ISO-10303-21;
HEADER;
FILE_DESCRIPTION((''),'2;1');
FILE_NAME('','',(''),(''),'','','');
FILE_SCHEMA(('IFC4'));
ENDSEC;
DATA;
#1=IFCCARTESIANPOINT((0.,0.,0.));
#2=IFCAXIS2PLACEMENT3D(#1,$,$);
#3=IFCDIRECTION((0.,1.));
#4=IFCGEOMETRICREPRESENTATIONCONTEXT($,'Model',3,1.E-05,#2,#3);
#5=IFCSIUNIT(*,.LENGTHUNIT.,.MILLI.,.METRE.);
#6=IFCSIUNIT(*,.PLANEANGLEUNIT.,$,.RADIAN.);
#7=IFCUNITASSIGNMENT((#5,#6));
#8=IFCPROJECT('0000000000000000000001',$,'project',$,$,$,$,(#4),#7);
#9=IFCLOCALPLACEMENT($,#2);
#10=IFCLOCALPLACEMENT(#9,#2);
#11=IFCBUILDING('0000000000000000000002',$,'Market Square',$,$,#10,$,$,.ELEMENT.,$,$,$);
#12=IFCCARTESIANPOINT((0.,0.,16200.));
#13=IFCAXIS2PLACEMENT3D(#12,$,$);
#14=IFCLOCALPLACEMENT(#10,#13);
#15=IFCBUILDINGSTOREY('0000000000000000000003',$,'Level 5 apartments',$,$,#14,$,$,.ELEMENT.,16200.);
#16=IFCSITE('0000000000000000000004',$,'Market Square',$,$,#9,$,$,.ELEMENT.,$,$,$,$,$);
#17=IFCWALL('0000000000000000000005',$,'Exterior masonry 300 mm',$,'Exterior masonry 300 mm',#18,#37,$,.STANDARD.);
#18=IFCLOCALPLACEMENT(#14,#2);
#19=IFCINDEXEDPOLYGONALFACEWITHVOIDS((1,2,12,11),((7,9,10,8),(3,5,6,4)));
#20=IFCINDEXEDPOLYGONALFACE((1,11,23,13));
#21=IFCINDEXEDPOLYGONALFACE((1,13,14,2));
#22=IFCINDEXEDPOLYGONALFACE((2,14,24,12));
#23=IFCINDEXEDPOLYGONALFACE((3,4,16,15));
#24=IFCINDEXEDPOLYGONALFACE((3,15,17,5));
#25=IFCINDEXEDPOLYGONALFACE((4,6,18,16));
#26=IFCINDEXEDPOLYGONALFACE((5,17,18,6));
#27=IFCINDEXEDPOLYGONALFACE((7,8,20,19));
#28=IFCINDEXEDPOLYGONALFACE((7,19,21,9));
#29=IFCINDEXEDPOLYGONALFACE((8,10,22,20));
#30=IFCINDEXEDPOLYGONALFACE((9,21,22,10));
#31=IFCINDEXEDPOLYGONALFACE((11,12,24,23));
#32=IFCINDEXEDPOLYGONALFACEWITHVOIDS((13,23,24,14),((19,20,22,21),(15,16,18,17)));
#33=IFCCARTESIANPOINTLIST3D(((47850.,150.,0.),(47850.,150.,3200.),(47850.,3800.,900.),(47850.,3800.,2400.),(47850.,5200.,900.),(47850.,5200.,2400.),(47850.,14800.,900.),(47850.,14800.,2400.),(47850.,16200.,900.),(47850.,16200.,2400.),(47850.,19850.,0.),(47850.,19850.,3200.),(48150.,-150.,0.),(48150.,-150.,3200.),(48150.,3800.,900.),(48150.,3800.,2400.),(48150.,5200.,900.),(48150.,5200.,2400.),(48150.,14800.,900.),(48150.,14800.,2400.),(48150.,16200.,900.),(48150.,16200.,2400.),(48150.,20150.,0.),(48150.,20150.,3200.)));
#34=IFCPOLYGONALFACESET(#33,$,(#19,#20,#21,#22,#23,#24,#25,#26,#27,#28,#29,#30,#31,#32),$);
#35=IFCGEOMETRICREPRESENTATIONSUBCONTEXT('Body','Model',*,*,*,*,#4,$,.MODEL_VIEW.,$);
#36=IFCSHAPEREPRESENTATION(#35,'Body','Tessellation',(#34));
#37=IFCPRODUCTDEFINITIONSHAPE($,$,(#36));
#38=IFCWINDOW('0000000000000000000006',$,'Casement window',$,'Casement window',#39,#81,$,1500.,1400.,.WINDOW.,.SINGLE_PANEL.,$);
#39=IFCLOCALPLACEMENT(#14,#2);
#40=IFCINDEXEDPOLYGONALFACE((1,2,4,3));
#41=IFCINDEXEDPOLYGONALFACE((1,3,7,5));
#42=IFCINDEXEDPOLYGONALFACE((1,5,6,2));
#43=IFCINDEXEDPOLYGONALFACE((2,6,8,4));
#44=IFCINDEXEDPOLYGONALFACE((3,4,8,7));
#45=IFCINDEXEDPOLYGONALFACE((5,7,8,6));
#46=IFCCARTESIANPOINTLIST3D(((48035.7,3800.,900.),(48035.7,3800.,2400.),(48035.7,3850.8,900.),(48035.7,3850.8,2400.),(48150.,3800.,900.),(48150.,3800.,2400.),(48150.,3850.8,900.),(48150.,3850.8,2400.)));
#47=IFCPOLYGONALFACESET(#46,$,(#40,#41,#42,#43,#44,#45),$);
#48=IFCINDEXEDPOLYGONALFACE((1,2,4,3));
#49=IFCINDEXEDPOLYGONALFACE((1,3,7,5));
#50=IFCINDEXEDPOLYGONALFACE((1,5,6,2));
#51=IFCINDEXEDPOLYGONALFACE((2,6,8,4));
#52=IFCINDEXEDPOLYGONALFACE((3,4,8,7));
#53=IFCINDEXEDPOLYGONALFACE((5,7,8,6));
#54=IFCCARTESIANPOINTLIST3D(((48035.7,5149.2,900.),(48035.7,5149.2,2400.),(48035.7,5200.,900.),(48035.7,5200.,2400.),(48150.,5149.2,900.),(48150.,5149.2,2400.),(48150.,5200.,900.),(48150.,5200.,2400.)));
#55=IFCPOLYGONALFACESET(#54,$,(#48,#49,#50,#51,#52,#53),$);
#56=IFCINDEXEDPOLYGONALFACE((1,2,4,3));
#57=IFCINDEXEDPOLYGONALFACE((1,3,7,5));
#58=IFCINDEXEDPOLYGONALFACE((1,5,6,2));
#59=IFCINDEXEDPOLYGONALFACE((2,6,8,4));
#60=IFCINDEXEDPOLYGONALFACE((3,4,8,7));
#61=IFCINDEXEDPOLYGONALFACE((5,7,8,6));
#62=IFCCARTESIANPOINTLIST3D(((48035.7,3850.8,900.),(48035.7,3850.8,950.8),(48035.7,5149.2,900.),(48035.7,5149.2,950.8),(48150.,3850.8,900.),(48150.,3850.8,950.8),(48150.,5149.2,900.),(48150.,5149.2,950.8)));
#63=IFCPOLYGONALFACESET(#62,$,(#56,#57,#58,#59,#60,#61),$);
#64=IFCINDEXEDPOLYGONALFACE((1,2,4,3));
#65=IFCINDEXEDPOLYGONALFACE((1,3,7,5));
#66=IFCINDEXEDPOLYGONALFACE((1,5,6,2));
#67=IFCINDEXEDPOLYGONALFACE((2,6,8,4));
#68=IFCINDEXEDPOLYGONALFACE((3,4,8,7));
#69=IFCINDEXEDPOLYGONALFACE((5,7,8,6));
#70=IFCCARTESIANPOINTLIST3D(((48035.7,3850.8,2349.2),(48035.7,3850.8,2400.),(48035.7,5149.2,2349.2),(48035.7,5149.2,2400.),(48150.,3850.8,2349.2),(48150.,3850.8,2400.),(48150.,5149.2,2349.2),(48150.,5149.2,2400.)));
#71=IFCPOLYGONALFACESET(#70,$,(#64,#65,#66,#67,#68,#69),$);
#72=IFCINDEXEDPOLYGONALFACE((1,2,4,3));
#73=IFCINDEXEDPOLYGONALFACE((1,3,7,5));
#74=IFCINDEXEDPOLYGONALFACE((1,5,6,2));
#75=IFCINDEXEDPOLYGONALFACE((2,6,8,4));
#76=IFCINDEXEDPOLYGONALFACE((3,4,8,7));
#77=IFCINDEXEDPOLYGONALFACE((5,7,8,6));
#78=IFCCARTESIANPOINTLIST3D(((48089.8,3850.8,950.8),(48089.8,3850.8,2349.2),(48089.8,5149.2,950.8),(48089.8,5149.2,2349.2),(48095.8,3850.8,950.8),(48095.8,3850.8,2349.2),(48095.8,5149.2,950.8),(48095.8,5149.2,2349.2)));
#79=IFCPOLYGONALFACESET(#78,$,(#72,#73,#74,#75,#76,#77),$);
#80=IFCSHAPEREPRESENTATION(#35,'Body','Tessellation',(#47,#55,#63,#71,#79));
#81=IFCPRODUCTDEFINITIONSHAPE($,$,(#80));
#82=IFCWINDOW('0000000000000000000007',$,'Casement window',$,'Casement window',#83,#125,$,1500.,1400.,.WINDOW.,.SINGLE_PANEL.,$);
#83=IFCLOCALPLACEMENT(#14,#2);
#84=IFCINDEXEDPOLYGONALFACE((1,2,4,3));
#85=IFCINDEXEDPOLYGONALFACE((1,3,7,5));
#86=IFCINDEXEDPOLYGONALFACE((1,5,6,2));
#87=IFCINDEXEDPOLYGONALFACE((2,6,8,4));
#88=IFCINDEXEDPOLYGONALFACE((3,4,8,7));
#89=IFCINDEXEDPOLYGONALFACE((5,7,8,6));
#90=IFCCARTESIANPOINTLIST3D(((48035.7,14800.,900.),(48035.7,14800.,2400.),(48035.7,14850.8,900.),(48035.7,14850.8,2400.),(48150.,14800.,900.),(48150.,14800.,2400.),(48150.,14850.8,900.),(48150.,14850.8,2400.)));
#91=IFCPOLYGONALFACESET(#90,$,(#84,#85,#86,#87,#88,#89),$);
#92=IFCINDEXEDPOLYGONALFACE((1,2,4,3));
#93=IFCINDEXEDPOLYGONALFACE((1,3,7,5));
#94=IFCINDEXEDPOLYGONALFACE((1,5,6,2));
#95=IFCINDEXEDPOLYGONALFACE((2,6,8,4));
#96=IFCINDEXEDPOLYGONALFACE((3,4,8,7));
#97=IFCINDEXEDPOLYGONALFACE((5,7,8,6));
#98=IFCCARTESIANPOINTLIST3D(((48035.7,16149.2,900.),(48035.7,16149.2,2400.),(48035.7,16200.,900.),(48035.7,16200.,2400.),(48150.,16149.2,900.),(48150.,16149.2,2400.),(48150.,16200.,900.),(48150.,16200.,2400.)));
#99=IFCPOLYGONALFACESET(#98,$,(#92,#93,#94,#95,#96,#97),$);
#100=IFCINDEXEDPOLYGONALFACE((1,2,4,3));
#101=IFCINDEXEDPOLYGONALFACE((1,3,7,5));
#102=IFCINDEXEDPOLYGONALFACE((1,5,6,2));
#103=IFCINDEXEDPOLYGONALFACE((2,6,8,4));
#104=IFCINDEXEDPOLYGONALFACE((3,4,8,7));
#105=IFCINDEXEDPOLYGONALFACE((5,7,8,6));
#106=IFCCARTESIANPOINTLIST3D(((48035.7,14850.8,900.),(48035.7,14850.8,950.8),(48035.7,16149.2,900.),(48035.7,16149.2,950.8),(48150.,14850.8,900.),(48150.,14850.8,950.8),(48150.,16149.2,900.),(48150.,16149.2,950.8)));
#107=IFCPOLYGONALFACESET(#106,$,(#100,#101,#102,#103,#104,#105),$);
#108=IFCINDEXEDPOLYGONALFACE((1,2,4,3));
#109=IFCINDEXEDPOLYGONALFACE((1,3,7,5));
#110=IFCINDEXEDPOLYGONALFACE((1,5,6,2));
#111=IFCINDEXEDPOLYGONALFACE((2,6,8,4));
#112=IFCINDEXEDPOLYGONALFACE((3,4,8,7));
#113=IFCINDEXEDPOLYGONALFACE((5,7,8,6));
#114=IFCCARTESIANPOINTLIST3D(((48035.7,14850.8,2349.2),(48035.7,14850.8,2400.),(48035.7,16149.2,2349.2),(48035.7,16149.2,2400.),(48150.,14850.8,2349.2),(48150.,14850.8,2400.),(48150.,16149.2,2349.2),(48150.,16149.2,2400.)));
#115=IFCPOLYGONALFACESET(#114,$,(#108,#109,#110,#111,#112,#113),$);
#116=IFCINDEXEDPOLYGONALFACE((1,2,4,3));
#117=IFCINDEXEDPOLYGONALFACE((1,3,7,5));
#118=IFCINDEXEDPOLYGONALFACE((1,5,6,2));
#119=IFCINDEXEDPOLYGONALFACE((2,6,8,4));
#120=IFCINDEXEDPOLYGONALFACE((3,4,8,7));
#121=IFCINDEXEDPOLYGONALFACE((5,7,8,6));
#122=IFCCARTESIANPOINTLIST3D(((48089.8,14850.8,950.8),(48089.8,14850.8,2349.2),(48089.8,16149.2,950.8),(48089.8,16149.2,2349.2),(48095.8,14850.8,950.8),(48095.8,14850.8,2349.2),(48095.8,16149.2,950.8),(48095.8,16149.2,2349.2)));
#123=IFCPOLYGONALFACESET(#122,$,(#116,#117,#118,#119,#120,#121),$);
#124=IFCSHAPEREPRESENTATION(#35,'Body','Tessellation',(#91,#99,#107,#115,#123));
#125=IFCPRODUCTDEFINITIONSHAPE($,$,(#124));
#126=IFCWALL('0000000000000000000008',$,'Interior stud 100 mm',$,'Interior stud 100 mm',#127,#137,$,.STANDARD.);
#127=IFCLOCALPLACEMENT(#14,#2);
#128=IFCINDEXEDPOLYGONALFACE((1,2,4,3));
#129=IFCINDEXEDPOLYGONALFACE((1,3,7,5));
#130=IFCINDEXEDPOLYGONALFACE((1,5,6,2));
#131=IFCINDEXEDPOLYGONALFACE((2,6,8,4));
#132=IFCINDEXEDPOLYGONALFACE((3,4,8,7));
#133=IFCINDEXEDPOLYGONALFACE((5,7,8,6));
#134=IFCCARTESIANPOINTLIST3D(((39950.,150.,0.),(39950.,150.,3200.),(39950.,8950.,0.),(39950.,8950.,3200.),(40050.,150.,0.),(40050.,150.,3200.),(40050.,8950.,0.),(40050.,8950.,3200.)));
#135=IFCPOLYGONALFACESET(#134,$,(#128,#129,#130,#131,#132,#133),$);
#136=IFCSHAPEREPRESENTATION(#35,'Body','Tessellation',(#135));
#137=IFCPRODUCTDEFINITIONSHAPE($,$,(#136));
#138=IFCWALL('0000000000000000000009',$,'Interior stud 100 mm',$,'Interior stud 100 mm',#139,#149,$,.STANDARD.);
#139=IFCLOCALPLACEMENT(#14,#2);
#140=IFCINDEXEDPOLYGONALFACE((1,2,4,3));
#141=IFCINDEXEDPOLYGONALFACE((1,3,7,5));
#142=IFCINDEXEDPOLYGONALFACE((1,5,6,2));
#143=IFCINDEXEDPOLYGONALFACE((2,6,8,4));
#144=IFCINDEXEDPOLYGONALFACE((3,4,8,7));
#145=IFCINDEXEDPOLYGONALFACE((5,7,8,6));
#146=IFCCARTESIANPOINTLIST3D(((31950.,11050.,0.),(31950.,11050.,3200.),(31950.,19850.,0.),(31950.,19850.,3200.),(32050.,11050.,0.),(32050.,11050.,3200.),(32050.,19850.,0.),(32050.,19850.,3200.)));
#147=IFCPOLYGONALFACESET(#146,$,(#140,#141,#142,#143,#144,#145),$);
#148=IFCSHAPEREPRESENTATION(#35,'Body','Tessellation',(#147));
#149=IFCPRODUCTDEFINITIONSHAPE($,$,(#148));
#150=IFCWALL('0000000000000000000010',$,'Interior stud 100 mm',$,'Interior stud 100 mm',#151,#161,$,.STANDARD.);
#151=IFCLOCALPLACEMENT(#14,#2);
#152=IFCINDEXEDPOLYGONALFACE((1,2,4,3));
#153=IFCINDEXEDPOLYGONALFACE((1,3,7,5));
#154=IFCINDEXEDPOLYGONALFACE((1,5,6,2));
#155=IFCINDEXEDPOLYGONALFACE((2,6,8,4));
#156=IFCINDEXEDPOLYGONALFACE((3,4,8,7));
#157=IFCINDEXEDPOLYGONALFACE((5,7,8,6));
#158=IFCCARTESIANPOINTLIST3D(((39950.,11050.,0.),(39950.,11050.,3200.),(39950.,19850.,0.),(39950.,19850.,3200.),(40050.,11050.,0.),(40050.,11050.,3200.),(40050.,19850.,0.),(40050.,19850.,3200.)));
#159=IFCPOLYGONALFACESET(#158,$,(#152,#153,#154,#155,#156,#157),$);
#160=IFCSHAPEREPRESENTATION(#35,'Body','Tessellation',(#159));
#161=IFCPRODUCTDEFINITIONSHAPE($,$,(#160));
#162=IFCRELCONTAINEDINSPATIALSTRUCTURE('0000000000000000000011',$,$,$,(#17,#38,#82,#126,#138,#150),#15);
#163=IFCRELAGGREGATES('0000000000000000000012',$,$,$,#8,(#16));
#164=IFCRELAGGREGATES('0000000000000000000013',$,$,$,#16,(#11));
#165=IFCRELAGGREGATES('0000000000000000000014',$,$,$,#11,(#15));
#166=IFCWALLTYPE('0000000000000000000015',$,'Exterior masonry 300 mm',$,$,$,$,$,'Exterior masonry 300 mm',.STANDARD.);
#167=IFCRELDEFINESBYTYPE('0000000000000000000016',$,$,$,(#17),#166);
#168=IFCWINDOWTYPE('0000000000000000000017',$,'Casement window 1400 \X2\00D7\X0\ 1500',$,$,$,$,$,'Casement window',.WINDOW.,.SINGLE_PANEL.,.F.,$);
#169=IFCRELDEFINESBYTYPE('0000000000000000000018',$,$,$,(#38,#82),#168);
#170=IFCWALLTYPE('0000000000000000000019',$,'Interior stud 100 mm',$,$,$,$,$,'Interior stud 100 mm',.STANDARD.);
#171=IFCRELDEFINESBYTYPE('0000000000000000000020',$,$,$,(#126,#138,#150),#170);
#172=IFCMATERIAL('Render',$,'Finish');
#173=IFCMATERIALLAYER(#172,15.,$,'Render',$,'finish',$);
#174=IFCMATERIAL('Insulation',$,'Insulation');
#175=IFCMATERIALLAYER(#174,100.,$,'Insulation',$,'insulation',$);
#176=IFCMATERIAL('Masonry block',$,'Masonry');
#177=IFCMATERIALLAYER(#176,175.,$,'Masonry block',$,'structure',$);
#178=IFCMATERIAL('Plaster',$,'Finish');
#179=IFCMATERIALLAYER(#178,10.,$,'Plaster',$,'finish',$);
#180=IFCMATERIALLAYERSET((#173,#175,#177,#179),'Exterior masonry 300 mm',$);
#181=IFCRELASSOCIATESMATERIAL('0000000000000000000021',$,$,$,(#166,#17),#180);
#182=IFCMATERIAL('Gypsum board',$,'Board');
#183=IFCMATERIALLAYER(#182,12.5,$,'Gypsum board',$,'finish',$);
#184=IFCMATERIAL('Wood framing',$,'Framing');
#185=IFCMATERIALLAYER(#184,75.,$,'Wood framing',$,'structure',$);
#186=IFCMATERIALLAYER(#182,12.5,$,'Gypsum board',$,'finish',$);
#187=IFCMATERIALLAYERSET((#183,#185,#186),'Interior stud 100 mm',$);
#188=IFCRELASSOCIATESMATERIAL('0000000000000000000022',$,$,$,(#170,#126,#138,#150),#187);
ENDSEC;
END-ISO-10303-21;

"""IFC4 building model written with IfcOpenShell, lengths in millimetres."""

from ifc_helpers import new_model, si_unit, direction, frame, origin, origin_with_axes, place, context, subcontext, project, spatial, polyline, outline, extrude, material, layer, layer_set, layer_usage, type_object, element, fill, save


model = new_model("IFC4")

# Units and contexts
model_context = context("Model", 3, precision=1e-05, world=origin(), true_north=direction((0.0, 1.0)))
body_context = subcontext(model_context, "Body", "Model", "MODEL_VIEW")
ifc_project = project(units=[si_unit("LENGTHUNIT", "METRE", prefix="MILLI"), si_unit("PLANEANGLEUNIT", "RADIAN")], contexts=[model_context])

# Site, building, storey
site_placement = place(None, origin())
site = spatial("IfcSite", under=ifc_project, at=site_placement, Name="Market Square", CompositionType="ELEMENT")
building_placement = place(site_placement, origin())
building = spatial("IfcBuilding", under=site, at=building_placement, Name="Market Square", CompositionType="ELEMENT")
storey_placement = place(building_placement, frame((0.0, 0.0, 16200.0)))
storey = spatial("IfcBuildingStorey", under=building, at=storey_placement, Name="Level 5 apartments", CompositionType="ELEMENT", Elevation=16200.0)

# Wall, openings, windows
ifc_material_1 = material(Name="Render", Category="Finish")
ifc_layer_1 = layer(ifc_material_1, 15.0, Name="Render", Category="finish")
ifc_material_2 = material(Name="Insulation", Category="Insulation")
ifc_layer_2 = layer(ifc_material_2, 100.0, Name="Insulation", Category="insulation")
ifc_material_3 = material(Name="Masonry block", Category="Masonry")
ifc_layer_3 = layer(ifc_material_3, 175.0, Name="Masonry block", Category="structure")
ifc_material_4 = material(Name="Plaster", Category="Finish")
ifc_layer_4 = layer(ifc_material_4, 10.0, Name="Plaster", Category="finish")
ifc_layer_set_1 = layer_set([ifc_layer_1, ifc_layer_2, ifc_layer_3, ifc_layer_4], Name="Exterior masonry 300 mm")
ifc_layer_usage_1 = layer_usage(ifc_layer_set_1, "AXIS2", "POSITIVE", -150.0)
wall_type_1 = type_object("IfcWallType", Name="Exterior masonry 300 mm", ElementType="Exterior masonry 300 mm", PredefinedType="STANDARD", material=ifc_layer_set_1)
wall_1_placement = place(storey_placement, frame((48000.0, 0.0, 0.0), z_axis=(0.0, 0.0, 1.0), x_axis=(0.0, 1.0, 0.0)))
wall_1 = element("IfcWall", 1, at=wall_1_placement, inside=storey, type_object=wall_type_1, material=ifc_layer_usage_1, Name="Exterior masonry 300 mm", ObjectType="Exterior masonry 300 mm", PredefinedType="STANDARD", context=body_context, shape_type="SweptSolid", body=[
    extrude(outline(polyline([(-150.0, -150.0), (20150.0, -150.0), (19850.0, 150.0), (150.0, 150.0), (-150.0, -150.0)])), origin(), (0.0, 0.0, 1.0), 3200.0),
])
opening_1_placement = place(wall_1_placement, frame((3800.0, 0.0, 900.0), z_axis=(0.0, 0.0, 1.0), x_axis=(1.0, 0.0, 0.0)))
opening_1 = element("IfcOpeningElement", 2, at=opening_1_placement, cuts=wall_1, PredefinedType="OPENING", context=body_context, shape_type="SweptSolid", body=[
    extrude(outline(polyline([(0.0, -160.0), (1400.0, -160.0), (1400.0, 160.0), (0.0, 160.0), (0.0, -160.0)])), origin(), (0.0, 0.0, 1.0), 1500.0),
])
opening_2_placement = place(wall_1_placement, frame((14800.0, 0.0, 900.0), z_axis=(0.0, 0.0, 1.0), x_axis=(1.0, 0.0, 0.0)))
opening_2 = element("IfcOpeningElement", 3, at=opening_2_placement, cuts=wall_1, PredefinedType="OPENING", context=body_context, shape_type="SweptSolid", body=[
    extrude(outline(polyline([(0.0, -160.0), (1400.0, -160.0), (1400.0, 160.0), (0.0, 160.0), (0.0, -160.0)])), origin(), (0.0, 0.0, 1.0), 1500.0),
])
window_type = type_object("IfcWindowType", Name="Casement window 1400 × 1500", ElementType="Casement window", ParameterTakesPrecedence=False, PartitioningType="SINGLE_PANEL", PredefinedType="WINDOW")
window_1_placement = place(opening_1_placement, origin_with_axes())
window_1 = element("IfcWindow", 4, at=window_1_placement, inside=storey, type_object=window_type, Name="Casement window", ObjectType="Casement window", OverallHeight=1500.0, OverallWidth=1400.0, PartitioningType="SINGLE_PANEL", PredefinedType="WINDOW", context=body_context, shape_type="SweptSolid", body=[
    extrude(outline(polyline([(0.0, -150.0), (50.8, -150.0), (50.8, -35.7), (0.0, -35.7), (0.0, -150.0)])), origin(), (0.0, 0.0, 1.0), 1500.0),
    extrude(outline(polyline([(1349.2, -150.0), (1400.0, -150.0), (1400.0, -35.7), (1349.2, -35.7), (1349.2, -150.0)])), origin(), (0.0, 0.0, 1.0), 1500.0),
    extrude(outline(polyline([(50.8, -150.0), (1349.2, -150.0), (1349.2, -35.7), (50.8, -35.7), (50.8, -150.0)])), origin(), (0.0, 0.0, 1.0), 50.8),
    extrude(outline(polyline([(50.8, -150.0), (1349.2, -150.0), (1349.2, -35.7), (50.8, -35.7), (50.8, -150.0)])), frame((0.0, 0.0, 1449.2)), (0.0, 0.0, 1.0), 50.8),
    extrude(outline(polyline([(50.8, -95.8), (1349.2, -95.8), (1349.2, -89.8), (50.8, -89.8), (50.8, -95.8)])), frame((0.0, 0.0, 50.8)), (0.0, 0.0, 1.0), 1398.4),
])
fill(opening_1, window_1)
window_2_placement = place(opening_2_placement, origin_with_axes())
window_2 = element("IfcWindow", 5, at=window_2_placement, inside=storey, type_object=window_type, Name="Casement window", ObjectType="Casement window", OverallHeight=1500.0, OverallWidth=1400.0, PartitioningType="SINGLE_PANEL", PredefinedType="WINDOW", context=body_context, shape_type="SweptSolid", body=[
    extrude(outline(polyline([(0.0, -150.0), (50.8, -150.0), (50.8, -35.7), (0.0, -35.7), (0.0, -150.0)])), origin(), (0.0, 0.0, 1.0), 1500.0),
    extrude(outline(polyline([(1349.2, -150.0), (1400.0, -150.0), (1400.0, -35.7), (1349.2, -35.7), (1349.2, -150.0)])), origin(), (0.0, 0.0, 1.0), 1500.0),
    extrude(outline(polyline([(50.8, -150.0), (1349.2, -150.0), (1349.2, -35.7), (50.8, -35.7), (50.8, -150.0)])), origin(), (0.0, 0.0, 1.0), 50.8),
    extrude(outline(polyline([(50.8, -150.0), (1349.2, -150.0), (1349.2, -35.7), (50.8, -35.7), (50.8, -150.0)])), frame((0.0, 0.0, 1449.2)), (0.0, 0.0, 1.0), 50.8),
    extrude(outline(polyline([(50.8, -95.8), (1349.2, -95.8), (1349.2, -89.8), (50.8, -89.8), (50.8, -95.8)])), frame((0.0, 0.0, 50.8)), (0.0, 0.0, 1.0), 1398.4),
])
fill(opening_2, window_2)

# Walls
ifc_material_5 = material(Name="Gypsum board", Category="Board")
ifc_layer_5 = layer(ifc_material_5, 12.5, Name="Gypsum board", Category="finish")
ifc_material_6 = material(Name="Wood framing", Category="Framing")
ifc_layer_6 = layer(ifc_material_6, 75.0, Name="Wood framing", Category="structure")
ifc_layer_7 = layer(ifc_material_5, 12.5, Name="Gypsum board", Category="finish")
ifc_layer_set_2 = layer_set([ifc_layer_5, ifc_layer_6, ifc_layer_7], Name="Interior stud 100 mm")
ifc_layer_usage_2 = layer_usage(ifc_layer_set_2, "AXIS2", "NEGATIVE", 50.0)
wall_type_2 = type_object("IfcWallType", Name="Interior stud 100 mm", ElementType="Interior stud 100 mm", PredefinedType="STANDARD", material=ifc_layer_set_2)
wall_2_placement = place(storey_placement, frame((40000.0, 0.0, 0.0), z_axis=(0.0, 0.0, 1.0), x_axis=(0.0, 1.0, 0.0)))
element("IfcWall", 6, at=wall_2_placement, inside=storey, type_object=wall_type_2, material=ifc_layer_usage_2, Name="Interior stud 100 mm", ObjectType="Interior stud 100 mm", PredefinedType="STANDARD", context=body_context, shape_type="SweptSolid", body=[
    extrude(outline(polyline([(150.0, -50.0), (8950.0, -50.0), (8950.0, 50.0), (150.0, 50.0), (150.0, -50.0)])), origin(), (0.0, 0.0, 1.0), 3200.0),
])
ifc_layer_usage_3 = layer_usage(ifc_layer_set_2, "AXIS2", "NEGATIVE", 50.0)
wall_3_placement = place(storey_placement, frame((32000.0, 11000.0, 0.0), z_axis=(0.0, 0.0, 1.0), x_axis=(0.0, 1.0, 0.0)))
element("IfcWall", 7, at=wall_3_placement, inside=storey, type_object=wall_type_2, material=ifc_layer_usage_3, Name="Interior stud 100 mm", ObjectType="Interior stud 100 mm", PredefinedType="STANDARD", context=body_context, shape_type="SweptSolid", body=[
    extrude(outline(polyline([(50.0, -50.0), (8850.0, -50.0), (8850.0, 50.0), (50.0, 50.0), (50.0, -50.0)])), origin(), (0.0, 0.0, 1.0), 3200.0),
])
ifc_layer_usage_4 = layer_usage(ifc_layer_set_2, "AXIS2", "NEGATIVE", 50.0)
wall_4_placement = place(storey_placement, frame((40000.0, 11000.0, 0.0), z_axis=(0.0, 0.0, 1.0), x_axis=(0.0, 1.0, 0.0)))
element("IfcWall", 8, at=wall_4_placement, inside=storey, type_object=wall_type_2, material=ifc_layer_usage_4, Name="Interior stud 100 mm", ObjectType="Interior stud 100 mm", PredefinedType="STANDARD", context=body_context, shape_type="SweptSolid", body=[
    extrude(outline(polyline([(50.0, -50.0), (8850.0, -50.0), (8850.0, 50.0), (50.0, 50.0), (50.0, -50.0)])), origin(), (0.0, 0.0, 1.0), 3200.0),
])

save(model, "model.ifc")
